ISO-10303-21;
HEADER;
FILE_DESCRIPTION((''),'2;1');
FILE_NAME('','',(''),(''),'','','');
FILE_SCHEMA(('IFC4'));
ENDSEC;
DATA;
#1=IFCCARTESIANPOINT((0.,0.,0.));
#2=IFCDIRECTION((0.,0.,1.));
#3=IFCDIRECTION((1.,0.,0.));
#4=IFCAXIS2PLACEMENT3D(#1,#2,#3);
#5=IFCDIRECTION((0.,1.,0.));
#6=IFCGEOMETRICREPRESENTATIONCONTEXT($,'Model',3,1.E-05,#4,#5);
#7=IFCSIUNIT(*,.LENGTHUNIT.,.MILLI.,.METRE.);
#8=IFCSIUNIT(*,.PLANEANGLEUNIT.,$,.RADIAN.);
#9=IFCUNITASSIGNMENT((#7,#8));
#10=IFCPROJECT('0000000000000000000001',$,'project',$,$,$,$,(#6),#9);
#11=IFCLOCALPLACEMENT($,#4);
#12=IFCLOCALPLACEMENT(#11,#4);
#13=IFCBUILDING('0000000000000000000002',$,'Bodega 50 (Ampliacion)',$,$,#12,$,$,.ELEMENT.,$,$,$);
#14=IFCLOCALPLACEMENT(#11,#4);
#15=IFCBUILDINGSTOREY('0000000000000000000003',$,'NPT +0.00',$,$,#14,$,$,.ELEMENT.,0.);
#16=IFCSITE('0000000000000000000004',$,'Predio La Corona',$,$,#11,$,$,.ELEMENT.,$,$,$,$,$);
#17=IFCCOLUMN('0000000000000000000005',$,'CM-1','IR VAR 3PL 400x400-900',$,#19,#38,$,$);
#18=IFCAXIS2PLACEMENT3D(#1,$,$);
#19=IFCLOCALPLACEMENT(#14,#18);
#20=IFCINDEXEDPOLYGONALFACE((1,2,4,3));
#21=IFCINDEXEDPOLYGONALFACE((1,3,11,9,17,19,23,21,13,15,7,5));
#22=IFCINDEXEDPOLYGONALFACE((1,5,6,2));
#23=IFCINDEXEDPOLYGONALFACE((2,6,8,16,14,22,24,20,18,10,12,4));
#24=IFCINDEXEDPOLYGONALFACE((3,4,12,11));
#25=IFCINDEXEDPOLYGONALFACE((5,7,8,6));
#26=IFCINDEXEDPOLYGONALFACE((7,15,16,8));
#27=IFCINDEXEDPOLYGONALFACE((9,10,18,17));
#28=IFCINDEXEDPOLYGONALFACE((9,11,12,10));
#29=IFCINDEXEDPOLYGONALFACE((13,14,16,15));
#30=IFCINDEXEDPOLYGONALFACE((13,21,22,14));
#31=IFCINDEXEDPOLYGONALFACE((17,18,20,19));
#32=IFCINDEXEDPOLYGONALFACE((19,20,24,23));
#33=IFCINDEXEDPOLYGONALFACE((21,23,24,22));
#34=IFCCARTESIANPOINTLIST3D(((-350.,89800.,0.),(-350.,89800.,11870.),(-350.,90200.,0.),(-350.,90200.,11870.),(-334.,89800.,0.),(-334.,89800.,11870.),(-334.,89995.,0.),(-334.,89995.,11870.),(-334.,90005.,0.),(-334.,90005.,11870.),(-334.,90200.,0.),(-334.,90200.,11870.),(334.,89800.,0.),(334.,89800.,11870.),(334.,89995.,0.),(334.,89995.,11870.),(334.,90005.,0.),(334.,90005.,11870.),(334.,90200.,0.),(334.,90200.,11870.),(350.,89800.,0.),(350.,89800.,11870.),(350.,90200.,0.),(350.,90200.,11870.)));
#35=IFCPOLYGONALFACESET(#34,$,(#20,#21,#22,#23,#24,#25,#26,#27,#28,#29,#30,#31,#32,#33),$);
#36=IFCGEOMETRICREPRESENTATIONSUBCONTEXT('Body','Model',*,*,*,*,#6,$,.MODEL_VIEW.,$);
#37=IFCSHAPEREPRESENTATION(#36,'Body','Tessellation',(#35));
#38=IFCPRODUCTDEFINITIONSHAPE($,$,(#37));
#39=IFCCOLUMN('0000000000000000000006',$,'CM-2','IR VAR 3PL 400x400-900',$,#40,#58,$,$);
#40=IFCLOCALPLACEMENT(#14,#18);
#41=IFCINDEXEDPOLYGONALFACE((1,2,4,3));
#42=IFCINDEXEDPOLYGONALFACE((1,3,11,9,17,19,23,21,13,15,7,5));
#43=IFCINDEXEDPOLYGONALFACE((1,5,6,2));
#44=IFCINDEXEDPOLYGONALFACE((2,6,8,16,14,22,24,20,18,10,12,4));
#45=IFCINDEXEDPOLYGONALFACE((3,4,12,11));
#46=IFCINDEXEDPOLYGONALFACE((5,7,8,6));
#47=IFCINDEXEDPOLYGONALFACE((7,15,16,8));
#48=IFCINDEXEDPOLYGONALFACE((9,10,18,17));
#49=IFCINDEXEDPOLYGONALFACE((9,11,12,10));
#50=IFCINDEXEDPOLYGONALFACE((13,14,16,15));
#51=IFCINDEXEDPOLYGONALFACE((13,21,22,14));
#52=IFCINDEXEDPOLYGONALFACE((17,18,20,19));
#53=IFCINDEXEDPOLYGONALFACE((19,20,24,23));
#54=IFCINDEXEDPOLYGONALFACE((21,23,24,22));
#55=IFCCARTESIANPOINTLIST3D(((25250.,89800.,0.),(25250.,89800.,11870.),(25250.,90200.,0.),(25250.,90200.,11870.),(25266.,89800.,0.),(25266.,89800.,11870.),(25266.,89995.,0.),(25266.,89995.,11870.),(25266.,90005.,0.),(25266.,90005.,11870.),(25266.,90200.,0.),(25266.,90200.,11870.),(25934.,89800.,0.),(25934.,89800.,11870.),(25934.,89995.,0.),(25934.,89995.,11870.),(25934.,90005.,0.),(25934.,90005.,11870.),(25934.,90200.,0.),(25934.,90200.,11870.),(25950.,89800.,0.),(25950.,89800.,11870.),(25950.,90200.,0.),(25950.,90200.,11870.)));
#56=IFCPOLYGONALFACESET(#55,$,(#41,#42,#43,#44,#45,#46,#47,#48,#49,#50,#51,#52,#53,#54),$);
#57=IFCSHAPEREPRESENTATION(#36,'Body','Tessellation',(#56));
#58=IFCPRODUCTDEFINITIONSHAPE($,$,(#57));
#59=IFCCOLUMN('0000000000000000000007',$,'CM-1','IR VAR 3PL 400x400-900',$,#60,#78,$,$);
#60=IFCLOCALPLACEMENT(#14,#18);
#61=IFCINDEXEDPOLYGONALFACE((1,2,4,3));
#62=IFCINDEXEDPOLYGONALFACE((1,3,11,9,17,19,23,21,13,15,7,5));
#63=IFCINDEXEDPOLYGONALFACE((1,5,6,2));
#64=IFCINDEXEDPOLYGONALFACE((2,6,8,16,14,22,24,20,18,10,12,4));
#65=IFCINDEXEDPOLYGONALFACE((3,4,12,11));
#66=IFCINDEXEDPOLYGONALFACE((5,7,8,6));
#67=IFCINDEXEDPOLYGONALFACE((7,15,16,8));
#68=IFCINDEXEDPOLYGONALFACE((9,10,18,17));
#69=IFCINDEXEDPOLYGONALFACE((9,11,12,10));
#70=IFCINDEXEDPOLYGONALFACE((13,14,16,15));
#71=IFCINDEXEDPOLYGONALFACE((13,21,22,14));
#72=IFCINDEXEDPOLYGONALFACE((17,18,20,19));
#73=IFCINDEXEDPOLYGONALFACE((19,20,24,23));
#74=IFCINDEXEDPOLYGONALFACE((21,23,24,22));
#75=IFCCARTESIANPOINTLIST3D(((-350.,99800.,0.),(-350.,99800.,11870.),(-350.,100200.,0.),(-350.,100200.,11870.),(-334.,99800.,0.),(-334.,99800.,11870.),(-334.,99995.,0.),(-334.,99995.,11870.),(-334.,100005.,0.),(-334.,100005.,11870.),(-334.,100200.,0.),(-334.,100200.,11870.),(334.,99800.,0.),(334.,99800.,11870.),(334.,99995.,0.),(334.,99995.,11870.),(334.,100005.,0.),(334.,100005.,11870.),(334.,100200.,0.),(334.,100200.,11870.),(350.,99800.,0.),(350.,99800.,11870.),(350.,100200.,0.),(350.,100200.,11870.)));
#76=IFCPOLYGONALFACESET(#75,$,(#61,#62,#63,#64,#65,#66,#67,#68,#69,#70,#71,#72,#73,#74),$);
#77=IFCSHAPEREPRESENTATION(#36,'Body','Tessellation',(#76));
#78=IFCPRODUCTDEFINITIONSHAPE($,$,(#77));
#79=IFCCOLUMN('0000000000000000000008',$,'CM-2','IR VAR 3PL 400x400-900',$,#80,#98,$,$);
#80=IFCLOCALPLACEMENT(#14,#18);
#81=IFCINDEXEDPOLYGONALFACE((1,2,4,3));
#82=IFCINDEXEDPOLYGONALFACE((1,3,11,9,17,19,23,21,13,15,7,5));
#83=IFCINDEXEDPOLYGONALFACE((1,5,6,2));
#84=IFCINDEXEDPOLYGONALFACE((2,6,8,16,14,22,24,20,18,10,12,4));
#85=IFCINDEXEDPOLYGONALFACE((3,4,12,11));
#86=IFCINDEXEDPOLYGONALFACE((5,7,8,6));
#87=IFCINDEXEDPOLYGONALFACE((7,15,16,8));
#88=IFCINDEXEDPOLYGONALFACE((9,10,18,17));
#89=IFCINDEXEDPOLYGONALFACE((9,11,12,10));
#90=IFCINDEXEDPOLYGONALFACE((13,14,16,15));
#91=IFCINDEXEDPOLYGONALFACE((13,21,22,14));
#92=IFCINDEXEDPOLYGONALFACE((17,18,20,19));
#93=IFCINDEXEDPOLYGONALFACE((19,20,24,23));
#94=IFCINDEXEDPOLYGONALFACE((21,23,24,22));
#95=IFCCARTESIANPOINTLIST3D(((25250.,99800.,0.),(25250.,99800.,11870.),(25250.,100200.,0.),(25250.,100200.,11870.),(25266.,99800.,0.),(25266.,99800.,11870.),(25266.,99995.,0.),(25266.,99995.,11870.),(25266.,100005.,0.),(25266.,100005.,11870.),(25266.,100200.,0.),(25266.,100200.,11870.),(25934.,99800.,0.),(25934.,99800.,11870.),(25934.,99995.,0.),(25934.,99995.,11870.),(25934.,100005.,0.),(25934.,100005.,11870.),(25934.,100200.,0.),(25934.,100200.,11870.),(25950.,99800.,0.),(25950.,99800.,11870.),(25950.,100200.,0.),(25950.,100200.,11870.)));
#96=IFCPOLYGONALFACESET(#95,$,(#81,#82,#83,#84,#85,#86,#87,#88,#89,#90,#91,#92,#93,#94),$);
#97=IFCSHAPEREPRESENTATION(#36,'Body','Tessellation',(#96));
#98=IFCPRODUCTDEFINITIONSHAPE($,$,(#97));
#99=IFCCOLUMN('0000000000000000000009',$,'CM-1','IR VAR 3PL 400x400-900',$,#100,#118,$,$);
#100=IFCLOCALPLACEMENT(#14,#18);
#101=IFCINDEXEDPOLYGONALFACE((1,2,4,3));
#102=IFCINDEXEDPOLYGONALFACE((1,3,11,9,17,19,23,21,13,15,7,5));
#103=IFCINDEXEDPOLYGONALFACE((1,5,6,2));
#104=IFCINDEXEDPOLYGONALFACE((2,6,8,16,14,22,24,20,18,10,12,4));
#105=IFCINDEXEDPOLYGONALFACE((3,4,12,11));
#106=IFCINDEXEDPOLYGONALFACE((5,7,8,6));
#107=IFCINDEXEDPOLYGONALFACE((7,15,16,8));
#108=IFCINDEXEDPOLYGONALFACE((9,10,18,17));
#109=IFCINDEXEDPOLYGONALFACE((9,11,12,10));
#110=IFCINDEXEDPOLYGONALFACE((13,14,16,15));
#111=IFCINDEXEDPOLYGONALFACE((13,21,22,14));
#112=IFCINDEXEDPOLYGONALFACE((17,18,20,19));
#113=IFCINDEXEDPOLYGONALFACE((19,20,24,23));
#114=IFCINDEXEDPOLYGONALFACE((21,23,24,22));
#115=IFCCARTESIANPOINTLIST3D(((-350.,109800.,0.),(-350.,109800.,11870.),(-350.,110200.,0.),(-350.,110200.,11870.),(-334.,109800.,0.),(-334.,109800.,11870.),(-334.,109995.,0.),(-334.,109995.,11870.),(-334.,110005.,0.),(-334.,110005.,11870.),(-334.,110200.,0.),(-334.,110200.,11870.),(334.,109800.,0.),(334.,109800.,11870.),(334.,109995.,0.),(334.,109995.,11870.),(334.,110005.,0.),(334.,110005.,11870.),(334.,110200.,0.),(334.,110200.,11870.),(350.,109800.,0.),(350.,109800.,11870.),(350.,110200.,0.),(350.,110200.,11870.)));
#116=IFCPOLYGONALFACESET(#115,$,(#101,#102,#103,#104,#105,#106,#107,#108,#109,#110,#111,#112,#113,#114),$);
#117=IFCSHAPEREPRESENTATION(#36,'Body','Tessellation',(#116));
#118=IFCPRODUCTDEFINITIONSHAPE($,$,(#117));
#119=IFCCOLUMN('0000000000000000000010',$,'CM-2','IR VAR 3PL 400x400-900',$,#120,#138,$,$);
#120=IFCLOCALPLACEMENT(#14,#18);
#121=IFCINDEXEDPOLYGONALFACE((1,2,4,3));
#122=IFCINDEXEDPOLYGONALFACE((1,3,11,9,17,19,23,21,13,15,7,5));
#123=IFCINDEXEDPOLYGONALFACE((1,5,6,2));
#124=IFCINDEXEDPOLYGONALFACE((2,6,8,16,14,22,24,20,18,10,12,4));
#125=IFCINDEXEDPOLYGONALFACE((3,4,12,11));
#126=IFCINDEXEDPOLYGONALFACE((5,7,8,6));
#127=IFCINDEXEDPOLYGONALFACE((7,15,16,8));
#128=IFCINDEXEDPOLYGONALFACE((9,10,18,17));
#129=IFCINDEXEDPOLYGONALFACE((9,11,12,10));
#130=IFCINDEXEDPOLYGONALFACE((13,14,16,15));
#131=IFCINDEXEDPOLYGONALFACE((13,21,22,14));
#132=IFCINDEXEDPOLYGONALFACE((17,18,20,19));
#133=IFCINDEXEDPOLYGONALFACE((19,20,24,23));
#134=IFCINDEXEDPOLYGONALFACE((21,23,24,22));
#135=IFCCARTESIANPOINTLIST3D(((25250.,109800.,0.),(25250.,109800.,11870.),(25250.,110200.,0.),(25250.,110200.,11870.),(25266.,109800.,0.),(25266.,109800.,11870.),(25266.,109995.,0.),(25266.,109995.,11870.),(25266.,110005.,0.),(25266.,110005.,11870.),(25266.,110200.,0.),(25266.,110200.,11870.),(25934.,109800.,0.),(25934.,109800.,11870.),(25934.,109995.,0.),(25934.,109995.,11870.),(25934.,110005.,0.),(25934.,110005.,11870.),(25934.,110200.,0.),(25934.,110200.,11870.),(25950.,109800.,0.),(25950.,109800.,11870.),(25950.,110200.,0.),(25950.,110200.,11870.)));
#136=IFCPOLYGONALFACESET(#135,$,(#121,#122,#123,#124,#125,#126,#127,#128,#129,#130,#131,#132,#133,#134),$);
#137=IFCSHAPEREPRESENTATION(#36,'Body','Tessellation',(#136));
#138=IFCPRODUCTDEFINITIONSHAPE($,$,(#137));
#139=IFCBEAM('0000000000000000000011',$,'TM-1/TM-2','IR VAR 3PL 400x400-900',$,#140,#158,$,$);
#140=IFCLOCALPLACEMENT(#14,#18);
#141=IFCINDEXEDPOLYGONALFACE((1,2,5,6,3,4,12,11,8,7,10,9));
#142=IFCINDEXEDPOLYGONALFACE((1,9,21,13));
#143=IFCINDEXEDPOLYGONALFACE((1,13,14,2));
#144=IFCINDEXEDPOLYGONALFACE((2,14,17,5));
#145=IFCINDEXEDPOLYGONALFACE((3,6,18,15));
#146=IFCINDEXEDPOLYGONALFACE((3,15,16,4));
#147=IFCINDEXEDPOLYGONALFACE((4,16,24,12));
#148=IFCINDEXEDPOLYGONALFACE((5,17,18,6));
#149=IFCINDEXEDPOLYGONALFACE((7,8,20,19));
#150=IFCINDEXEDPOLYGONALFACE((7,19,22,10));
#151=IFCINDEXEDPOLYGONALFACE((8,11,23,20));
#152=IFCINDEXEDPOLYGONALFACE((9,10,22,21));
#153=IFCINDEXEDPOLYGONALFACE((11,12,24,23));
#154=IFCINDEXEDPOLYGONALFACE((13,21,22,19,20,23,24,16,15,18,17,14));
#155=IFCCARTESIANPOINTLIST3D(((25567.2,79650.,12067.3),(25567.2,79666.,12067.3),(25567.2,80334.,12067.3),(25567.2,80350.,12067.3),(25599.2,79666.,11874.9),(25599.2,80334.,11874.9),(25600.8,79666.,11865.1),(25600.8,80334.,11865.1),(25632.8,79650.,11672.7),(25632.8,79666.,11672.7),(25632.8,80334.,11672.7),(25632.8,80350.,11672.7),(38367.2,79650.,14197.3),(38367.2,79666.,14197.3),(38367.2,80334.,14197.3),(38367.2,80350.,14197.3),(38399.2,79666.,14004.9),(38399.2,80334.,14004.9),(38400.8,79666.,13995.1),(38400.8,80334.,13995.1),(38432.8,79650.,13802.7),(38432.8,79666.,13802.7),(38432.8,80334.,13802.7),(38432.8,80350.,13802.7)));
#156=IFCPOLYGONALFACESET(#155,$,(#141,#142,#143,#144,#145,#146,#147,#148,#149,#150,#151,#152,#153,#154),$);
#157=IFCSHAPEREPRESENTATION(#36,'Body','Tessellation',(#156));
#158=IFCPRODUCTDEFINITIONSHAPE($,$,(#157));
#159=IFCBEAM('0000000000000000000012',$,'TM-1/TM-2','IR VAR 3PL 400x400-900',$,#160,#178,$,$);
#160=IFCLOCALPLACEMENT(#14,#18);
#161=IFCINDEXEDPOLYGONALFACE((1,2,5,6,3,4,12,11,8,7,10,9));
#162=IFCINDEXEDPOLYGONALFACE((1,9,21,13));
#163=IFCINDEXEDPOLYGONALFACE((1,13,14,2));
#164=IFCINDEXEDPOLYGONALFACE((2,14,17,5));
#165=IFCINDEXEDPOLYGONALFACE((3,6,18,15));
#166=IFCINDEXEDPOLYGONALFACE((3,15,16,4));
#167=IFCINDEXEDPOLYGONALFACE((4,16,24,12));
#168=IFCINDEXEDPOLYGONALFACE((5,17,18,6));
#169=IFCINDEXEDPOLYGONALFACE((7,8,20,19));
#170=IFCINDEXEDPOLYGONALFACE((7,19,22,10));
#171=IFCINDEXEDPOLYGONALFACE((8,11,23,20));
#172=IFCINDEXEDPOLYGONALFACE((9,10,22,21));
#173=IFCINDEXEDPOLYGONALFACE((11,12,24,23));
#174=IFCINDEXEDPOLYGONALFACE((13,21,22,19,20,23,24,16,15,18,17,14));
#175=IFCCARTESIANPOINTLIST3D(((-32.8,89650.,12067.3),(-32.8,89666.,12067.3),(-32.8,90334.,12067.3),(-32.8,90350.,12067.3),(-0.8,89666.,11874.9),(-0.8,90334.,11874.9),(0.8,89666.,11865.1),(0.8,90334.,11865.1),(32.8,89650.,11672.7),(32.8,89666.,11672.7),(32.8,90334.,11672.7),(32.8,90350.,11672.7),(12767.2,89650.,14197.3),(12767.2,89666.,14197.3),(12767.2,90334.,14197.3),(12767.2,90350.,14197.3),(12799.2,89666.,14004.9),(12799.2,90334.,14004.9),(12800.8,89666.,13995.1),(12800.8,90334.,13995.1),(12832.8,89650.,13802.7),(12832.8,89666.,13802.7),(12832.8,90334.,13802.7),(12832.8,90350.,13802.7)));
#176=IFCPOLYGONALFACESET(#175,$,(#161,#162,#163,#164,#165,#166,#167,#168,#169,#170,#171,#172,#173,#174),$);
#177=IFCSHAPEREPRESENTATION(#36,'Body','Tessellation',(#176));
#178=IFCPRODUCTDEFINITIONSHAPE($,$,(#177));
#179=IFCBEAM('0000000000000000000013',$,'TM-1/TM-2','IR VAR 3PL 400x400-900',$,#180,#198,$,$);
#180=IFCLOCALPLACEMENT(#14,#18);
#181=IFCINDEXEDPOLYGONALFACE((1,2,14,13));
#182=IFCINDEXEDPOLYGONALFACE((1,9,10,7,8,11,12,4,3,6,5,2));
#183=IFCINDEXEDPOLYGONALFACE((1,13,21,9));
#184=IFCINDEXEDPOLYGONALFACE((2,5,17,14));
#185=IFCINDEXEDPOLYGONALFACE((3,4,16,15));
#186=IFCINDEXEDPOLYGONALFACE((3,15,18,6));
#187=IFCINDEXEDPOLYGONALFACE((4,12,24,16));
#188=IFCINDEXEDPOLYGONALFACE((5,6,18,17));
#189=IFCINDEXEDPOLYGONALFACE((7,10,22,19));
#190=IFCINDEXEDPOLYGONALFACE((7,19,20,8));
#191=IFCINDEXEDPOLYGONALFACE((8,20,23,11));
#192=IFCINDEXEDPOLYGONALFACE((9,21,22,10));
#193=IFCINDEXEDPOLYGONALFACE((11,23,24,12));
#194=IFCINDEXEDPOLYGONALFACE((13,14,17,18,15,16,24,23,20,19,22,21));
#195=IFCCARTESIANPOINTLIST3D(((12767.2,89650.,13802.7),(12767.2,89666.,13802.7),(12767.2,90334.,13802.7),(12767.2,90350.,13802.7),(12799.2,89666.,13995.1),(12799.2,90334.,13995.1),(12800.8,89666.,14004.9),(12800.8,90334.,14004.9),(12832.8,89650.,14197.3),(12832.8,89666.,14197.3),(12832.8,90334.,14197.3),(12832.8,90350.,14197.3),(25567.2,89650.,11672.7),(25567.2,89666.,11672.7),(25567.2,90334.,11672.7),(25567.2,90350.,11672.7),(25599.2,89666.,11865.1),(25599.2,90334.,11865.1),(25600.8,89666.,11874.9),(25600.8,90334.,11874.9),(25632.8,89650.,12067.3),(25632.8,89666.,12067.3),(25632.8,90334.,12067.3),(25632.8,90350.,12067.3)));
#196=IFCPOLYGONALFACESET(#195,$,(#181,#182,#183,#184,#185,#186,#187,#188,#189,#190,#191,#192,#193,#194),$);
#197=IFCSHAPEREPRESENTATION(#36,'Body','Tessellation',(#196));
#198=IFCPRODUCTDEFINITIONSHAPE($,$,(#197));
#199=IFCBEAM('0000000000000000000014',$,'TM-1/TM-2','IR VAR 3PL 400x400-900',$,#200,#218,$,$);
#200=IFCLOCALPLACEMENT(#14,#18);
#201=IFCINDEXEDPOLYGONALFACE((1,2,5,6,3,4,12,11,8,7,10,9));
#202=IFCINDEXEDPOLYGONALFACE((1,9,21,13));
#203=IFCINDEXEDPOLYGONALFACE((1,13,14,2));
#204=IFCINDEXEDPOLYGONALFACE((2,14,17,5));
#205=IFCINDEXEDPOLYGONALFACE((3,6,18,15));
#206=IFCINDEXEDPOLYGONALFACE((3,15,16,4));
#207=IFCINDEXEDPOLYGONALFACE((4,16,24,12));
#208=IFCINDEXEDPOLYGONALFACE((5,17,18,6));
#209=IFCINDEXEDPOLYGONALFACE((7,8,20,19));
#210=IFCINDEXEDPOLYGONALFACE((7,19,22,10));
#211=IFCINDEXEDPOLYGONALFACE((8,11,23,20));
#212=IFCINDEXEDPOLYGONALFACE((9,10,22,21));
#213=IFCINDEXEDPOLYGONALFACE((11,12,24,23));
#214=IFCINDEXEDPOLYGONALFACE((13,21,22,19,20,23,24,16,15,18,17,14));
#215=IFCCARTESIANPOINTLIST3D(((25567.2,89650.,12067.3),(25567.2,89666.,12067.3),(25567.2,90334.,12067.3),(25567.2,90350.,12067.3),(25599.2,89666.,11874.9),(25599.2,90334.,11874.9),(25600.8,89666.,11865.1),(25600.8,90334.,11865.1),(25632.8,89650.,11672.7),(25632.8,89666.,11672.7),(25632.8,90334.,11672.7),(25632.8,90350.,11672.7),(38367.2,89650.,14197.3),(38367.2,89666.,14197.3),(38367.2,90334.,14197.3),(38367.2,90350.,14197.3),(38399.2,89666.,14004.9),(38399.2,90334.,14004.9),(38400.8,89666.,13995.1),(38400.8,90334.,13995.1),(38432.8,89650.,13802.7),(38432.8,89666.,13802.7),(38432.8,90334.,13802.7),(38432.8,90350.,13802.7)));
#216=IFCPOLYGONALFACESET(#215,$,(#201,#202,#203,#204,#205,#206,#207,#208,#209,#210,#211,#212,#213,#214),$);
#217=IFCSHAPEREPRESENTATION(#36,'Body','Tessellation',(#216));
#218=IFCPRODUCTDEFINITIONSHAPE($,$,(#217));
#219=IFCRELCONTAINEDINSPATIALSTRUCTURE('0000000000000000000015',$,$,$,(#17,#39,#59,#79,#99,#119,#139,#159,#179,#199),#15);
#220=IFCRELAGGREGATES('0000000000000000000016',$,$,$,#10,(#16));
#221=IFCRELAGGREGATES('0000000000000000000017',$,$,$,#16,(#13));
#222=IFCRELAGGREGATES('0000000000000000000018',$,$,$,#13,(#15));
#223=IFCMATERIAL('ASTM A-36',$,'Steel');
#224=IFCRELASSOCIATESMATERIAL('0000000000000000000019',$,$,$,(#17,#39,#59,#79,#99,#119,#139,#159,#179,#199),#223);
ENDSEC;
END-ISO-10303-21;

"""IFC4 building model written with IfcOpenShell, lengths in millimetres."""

from ifc_helpers import new_model, si_unit, direction, frame, origin_with_axes, origin_2d, place, context, subcontext, project, spatial, i_section, extrude, material, element, save


model = new_model("IFC4")

# Units and contexts
model_context = context("Model", 3, precision=1e-05, world=origin_with_axes(), true_north=direction((0.0, 1.0, 0.0)))
body_context = subcontext(model_context, "Body", "Model", "MODEL_VIEW")
ifc_project = project(units=[si_unit("LENGTHUNIT", "METRE", prefix="MILLI"), si_unit("PLANEANGLEUNIT", "RADIAN")], contexts=[model_context])

# Site, building, storey
site_placement = place(None, origin_with_axes())
site = spatial("IfcSite", under=ifc_project, at=site_placement, Name="Predio La Corona", CompositionType="ELEMENT")
building_placement = place(site_placement, origin_with_axes())
building = spatial("IfcBuilding", under=site, at=building_placement, Name="Bodega 50 (Ampliacion)", CompositionType="ELEMENT")
storey_placement = place(site_placement, origin_with_axes())
storey = spatial("IfcBuildingStorey", under=building, at=storey_placement, Name="NPT +0.00", CompositionType="ELEMENT", Elevation=0.0)

# Columns
ifc_material = material(Name="ASTM A-36", Category="Steel")
for number, where, z_axis, x_axis, name in (
    (1, (0.0, 90000.0, 0.0), (0.0, 0.0, 1.0), (0.0, -1.0, 0.0), "CM-1"),
    (2, (25600.0, 90000.0, 0.0), (0.0, 0.0, 1.0), (0.0, -1.0, 0.0), "CM-2"),
    (3, (0.0, 100000.0, 0.0), (0.0, 0.0, 1.0), (0.0, -1.0, 0.0), "CM-1"),
    (4, (25600.0, 100000.0, 0.0), (0.0, 0.0, 1.0), (0.0, -1.0, 0.0), "CM-2"),
    (5, (0.0, 110000.0, 0.0), (0.0, 0.0, 1.0), (0.0, -1.0, 0.0), "CM-1"),
    (6, (25600.0, 110000.0, 0.0), (0.0, 0.0, 1.0), (0.0, -1.0, 0.0), "CM-2"),
):
    element("IfcColumn", number, at=place(storey_placement, frame(where, z_axis=z_axis, x_axis=x_axis)), inside=storey, material=ifc_material, Name=name, Description="IR VAR 3PL 400x400-900", context=body_context, shape_type="SweptSolid", body=[
        extrude(i_section(OverallWidth=400.0, OverallDepth=700.0, WebThickness=10.0, FlangeThickness=16.0, at=origin_2d()), origin_with_axes(), (0.0, 0.0, 1.0), 11870.0),
    ])

# Beams
for number, where, z_axis, x_axis, name in (
    (7, (25600.0, 80000.0, 11870.0), (0.986436, 0.0, 0.164149), (0.164149, 0.0, -0.986436), "TM-1/TM-2"),
    (8, (0.0, 90000.0, 11870.0), (0.986436, 0.0, 0.164149), (0.164149, 0.0, -0.986436), "TM-1/TM-2"),
    (9, (12800.0, 90000.0, 14000.0), (0.986436, 0.0, -0.164149), (-0.164149, 0.0, -0.986436), "TM-1/TM-2"),
    (10, (25600.0, 90000.0, 11870.0), (0.986436, 0.0, 0.164149), (0.164149, 0.0, -0.986436), "TM-1/TM-2"),
):
    element("IfcBeam", number, at=place(storey_placement, frame(where, z_axis=z_axis, x_axis=x_axis)), inside=storey, material=ifc_material, Name=name, Description="IR VAR 3PL 400x400-900", context=body_context, shape_type="SweptSolid", body=[
        extrude(i_section(OverallWidth=400.0, OverallDepth=700.0, WebThickness=10.0, FlangeThickness=16.0, at=origin_2d()), origin_with_axes(), (0.0, 0.0, 1.0), 12976.0),
    ])

save(model, "model.ifc")
